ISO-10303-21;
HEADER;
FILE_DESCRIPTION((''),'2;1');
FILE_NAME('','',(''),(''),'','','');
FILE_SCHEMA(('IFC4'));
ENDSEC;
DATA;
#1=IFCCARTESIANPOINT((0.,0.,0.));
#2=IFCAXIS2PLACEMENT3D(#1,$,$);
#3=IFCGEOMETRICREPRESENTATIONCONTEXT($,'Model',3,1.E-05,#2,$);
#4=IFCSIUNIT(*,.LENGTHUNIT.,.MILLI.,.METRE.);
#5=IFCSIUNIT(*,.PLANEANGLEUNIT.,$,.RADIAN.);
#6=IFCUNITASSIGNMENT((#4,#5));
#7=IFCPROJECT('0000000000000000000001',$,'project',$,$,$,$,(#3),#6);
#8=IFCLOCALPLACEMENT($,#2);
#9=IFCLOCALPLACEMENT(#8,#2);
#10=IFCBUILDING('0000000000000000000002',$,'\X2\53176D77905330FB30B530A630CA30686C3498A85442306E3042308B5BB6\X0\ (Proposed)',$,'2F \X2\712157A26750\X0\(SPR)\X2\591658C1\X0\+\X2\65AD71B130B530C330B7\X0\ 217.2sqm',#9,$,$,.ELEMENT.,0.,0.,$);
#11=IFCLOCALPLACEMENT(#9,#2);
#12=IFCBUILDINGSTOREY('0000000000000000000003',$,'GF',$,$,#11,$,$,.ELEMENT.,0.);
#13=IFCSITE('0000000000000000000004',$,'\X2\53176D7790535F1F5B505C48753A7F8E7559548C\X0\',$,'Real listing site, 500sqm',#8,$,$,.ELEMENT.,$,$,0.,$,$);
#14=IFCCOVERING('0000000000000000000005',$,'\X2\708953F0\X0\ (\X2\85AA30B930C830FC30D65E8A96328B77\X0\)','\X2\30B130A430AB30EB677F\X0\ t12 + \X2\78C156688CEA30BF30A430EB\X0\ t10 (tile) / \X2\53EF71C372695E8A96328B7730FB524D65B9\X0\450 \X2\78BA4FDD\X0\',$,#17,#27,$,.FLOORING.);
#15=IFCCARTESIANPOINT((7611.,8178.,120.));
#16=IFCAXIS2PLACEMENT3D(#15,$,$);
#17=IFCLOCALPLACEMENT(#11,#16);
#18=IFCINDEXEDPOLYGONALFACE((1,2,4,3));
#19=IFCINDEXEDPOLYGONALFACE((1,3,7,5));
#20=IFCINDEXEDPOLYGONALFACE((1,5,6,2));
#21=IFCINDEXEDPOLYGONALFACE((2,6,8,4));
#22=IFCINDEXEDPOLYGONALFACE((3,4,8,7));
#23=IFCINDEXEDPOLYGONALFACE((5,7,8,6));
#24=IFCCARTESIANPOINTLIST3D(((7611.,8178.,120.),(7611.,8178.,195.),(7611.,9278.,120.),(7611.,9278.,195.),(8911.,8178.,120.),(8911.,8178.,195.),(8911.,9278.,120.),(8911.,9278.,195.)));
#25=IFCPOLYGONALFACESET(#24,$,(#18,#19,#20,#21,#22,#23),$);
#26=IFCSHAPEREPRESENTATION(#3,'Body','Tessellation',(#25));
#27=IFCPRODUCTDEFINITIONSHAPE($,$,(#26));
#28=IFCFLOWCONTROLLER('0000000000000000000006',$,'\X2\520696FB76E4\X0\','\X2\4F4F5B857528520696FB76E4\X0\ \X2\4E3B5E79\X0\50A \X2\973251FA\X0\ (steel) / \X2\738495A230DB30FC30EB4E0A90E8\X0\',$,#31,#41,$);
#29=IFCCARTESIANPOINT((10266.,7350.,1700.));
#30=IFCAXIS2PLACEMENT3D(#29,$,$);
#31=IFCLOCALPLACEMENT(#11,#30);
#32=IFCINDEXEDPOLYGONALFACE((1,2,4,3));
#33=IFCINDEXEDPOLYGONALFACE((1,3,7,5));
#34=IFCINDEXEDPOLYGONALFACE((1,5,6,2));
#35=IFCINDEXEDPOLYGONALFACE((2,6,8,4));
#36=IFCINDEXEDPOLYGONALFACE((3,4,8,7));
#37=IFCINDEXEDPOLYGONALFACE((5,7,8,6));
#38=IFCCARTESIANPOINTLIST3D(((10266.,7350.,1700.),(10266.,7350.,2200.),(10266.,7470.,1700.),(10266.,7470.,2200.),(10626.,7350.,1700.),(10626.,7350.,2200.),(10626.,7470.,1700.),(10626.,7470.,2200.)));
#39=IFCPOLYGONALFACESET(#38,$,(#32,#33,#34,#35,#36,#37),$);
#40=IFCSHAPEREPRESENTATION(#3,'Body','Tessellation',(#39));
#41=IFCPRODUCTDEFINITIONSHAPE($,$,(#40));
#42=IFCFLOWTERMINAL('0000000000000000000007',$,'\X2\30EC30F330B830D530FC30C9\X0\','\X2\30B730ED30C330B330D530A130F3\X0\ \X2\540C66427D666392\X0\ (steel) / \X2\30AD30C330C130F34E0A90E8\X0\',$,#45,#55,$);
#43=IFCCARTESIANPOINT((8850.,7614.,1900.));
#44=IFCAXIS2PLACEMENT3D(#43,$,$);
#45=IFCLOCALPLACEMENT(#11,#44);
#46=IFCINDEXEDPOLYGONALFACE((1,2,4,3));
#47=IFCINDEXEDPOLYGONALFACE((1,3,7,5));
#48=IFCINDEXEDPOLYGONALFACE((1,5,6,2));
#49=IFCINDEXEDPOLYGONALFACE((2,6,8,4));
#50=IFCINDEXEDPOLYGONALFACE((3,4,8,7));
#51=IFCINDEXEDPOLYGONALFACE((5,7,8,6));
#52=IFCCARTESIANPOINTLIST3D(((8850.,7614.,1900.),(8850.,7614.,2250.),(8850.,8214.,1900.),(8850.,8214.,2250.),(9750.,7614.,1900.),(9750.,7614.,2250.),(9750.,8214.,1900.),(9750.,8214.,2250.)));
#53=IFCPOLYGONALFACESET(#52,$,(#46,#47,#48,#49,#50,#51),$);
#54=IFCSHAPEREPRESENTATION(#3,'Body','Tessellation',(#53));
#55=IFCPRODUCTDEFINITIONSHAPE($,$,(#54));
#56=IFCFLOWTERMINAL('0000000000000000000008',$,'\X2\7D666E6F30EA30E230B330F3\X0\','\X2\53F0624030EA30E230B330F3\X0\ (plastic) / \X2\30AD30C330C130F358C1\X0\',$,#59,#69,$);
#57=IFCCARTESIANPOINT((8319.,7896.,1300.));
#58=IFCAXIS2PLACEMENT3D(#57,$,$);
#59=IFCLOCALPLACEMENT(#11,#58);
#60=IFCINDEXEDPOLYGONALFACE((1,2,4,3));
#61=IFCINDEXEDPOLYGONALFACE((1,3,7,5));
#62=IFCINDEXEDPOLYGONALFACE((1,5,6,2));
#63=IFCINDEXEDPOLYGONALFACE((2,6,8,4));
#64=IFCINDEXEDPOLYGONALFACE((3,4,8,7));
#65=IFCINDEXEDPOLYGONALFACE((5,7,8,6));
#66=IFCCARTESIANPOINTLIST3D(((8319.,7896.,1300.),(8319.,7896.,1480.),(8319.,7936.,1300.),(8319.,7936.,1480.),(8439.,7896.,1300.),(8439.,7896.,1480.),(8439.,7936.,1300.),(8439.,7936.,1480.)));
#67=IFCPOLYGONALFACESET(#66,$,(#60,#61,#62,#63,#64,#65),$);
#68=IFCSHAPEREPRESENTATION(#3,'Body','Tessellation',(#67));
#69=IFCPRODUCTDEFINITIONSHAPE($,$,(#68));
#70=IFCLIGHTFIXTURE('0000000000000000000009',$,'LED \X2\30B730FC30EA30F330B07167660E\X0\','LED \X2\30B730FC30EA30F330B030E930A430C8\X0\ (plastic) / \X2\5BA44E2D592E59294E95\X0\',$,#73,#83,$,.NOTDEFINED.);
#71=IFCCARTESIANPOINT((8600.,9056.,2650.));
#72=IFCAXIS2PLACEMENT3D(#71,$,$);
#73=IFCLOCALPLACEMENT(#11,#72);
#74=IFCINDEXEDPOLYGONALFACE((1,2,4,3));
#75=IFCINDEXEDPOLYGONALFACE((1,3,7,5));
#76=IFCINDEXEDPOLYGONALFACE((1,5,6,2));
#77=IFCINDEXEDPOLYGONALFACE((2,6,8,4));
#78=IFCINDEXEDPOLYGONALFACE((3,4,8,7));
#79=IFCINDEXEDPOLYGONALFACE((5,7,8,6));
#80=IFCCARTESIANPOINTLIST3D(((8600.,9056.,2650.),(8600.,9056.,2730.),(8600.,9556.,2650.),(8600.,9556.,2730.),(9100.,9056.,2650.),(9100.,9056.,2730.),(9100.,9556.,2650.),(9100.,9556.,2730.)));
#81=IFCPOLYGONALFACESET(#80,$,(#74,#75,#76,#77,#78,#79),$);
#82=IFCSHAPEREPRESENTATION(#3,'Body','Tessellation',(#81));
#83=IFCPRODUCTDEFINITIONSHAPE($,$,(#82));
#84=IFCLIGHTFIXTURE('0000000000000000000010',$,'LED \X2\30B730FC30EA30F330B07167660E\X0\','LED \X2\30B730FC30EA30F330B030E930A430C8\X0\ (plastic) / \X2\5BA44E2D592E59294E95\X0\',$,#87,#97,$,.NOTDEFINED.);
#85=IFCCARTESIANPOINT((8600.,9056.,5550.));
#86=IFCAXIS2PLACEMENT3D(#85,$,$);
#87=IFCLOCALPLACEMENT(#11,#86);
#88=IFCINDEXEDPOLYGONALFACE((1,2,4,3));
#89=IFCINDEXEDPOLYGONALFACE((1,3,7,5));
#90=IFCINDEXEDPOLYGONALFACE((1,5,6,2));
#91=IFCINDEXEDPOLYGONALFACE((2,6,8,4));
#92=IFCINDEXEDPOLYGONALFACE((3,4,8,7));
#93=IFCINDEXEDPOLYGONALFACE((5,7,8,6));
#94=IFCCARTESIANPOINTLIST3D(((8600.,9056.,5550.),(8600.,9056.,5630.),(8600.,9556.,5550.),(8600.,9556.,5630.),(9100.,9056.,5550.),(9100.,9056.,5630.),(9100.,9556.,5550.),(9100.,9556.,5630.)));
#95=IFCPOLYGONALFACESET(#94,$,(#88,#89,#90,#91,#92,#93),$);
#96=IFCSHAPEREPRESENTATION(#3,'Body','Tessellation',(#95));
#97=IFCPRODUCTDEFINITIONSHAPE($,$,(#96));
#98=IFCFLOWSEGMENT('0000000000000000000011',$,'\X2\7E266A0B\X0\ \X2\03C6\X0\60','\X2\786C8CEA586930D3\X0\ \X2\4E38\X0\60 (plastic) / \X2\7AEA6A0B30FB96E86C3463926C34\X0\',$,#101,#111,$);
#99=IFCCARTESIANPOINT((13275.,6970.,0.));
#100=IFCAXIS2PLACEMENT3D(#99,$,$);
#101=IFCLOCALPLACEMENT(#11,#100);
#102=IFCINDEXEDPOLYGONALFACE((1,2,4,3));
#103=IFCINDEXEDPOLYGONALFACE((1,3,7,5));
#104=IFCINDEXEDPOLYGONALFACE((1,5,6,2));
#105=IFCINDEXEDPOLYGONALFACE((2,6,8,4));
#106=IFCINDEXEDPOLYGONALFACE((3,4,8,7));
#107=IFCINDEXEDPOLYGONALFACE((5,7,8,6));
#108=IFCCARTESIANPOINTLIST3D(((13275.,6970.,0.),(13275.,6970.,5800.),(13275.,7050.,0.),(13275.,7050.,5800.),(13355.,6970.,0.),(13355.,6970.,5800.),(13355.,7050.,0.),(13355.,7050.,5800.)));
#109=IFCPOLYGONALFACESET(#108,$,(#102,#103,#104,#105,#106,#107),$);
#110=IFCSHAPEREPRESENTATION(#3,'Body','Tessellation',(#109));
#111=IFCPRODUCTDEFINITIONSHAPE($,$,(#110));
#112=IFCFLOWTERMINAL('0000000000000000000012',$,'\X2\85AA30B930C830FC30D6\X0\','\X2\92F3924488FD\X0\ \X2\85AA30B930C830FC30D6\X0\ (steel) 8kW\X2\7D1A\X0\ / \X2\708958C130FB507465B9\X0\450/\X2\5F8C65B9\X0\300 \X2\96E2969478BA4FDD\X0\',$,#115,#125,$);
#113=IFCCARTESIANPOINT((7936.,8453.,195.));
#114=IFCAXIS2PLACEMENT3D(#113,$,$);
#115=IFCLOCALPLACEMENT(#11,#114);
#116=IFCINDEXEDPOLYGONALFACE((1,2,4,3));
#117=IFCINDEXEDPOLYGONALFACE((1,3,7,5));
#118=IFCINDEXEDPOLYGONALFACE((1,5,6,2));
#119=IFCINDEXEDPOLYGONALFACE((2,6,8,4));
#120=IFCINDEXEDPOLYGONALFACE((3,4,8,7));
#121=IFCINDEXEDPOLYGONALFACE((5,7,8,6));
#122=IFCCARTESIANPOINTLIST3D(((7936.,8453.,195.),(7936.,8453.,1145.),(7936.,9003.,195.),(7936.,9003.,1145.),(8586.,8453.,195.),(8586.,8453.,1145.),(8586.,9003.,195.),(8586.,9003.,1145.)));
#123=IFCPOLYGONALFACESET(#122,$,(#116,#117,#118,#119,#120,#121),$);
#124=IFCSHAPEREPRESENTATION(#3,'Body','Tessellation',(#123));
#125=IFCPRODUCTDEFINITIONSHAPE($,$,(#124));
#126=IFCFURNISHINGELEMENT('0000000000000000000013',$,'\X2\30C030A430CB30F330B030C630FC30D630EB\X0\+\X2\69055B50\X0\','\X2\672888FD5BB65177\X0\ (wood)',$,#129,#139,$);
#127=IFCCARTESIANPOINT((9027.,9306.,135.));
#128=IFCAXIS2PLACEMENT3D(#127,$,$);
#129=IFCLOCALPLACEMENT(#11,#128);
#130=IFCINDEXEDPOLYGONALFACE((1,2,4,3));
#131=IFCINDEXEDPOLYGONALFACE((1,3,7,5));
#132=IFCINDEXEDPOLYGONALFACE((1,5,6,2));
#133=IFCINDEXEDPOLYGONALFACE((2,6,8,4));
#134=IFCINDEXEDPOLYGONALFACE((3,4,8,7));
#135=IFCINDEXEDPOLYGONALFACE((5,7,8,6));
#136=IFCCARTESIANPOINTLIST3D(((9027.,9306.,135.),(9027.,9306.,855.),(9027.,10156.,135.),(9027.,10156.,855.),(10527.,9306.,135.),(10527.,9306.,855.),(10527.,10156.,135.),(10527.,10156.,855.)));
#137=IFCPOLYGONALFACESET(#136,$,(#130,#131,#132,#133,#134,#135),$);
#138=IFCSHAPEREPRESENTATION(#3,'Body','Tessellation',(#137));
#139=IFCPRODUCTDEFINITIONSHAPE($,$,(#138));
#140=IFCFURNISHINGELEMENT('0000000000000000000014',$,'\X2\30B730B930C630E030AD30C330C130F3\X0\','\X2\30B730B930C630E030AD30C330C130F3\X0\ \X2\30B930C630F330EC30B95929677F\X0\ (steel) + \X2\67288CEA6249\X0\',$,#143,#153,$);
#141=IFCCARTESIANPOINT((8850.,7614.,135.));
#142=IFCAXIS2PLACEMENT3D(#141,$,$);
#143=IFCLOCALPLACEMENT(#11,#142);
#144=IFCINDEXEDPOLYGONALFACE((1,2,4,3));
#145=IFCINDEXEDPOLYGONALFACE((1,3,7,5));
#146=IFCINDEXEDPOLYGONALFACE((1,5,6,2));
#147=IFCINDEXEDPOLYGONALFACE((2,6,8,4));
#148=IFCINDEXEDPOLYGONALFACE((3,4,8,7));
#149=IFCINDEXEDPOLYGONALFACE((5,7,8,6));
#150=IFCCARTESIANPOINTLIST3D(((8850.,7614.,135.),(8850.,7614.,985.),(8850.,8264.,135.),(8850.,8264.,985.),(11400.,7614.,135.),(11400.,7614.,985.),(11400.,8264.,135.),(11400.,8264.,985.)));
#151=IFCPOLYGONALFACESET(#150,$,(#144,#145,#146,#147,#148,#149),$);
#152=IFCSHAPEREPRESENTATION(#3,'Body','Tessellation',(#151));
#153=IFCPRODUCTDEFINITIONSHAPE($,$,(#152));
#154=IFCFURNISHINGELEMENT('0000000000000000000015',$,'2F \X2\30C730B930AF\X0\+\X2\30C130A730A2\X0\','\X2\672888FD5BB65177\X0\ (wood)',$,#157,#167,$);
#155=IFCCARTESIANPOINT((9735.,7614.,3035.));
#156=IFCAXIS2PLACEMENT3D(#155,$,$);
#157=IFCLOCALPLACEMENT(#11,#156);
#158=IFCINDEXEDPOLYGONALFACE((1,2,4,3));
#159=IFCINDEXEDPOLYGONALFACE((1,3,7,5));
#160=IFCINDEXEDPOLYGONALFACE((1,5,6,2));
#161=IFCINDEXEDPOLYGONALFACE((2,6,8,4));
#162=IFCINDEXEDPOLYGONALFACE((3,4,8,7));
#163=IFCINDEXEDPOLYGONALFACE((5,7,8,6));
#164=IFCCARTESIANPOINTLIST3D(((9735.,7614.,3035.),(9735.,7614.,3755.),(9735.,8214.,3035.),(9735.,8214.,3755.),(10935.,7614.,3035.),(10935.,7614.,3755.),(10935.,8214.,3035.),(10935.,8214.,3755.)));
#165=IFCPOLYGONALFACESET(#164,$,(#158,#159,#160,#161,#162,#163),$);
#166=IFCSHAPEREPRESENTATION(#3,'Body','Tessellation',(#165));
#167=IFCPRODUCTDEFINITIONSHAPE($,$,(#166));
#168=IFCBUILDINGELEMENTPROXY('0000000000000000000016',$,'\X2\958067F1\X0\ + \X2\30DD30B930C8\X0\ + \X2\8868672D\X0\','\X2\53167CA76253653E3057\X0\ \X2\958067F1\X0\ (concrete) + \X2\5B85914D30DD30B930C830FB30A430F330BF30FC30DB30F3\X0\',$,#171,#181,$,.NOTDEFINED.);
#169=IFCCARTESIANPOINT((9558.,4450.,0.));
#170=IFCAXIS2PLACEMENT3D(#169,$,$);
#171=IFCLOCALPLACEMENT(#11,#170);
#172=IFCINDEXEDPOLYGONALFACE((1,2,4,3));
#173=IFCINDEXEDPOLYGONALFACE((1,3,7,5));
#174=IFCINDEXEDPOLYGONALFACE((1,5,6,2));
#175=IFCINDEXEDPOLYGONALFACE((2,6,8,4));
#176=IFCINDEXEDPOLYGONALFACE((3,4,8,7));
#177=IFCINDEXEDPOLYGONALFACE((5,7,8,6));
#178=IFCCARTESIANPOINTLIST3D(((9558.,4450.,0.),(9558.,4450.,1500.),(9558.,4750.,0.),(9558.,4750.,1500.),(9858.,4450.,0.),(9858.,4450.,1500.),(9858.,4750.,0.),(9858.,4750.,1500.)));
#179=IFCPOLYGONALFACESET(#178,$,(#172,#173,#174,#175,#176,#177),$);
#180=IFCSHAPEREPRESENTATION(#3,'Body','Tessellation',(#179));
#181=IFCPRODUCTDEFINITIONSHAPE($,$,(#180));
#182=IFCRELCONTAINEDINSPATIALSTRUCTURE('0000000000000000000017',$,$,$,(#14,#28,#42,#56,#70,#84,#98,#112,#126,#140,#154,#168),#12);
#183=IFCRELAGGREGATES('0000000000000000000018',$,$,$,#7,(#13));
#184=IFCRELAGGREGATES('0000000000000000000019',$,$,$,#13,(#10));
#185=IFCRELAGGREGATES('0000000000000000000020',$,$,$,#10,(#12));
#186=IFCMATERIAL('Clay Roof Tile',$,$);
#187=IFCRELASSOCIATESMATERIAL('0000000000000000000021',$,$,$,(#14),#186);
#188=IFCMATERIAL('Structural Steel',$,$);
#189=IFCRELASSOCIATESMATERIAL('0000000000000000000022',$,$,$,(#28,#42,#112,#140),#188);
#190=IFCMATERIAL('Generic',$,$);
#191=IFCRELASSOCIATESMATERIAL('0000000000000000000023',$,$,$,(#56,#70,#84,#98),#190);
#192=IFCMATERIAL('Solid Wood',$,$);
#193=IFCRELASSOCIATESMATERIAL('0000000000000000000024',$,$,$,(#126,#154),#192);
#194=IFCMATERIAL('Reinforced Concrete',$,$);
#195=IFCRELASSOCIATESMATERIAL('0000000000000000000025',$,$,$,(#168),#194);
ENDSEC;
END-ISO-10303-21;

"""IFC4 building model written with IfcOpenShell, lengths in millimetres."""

from ifc_helpers import new_model, si_unit, frame, frame_2d, origin, place, context, project, spatial, rectangle, extrude, material, element, save


model = new_model("IFC4")

# Units and contexts
model_context = context("Model", 3, precision=1e-05, world=origin())
ifc_project = project(units=[si_unit("LENGTHUNIT", "METRE", prefix="MILLI"), si_unit("PLANEANGLEUNIT", "RADIAN")], contexts=[model_context])

# Site, building, storey
site_placement = place(None, origin())
site = spatial("IfcSite", under=ifc_project, at=site_placement, Name="北海道弟子屈町美留和", ObjectType="Real listing site, 500sqm", CompositionType="ELEMENT", RefElevation=0.0)
building_placement = place(site_placement, origin())
building = spatial("IfcBuilding", under=site, at=building_placement, Name="北海道・サウナと水風呂のある家 (Proposed)", ObjectType="2F 無垢材(SPR)外壁+断熱サッシ 217.2sqm", CompositionType="ELEMENT", ElevationOfRefHeight=0.0, ElevationOfTerrain=0.0)
storey_placement = place(building_placement, origin())
storey = spatial("IfcBuildingStorey", under=building, at=storey_placement, Name="GF", CompositionType="ELEMENT", Elevation=0.0)

# Shared definitions
ifc_material_1 = material(Name="Solid Wood")

# Shared definitions
ifc_material_2 = material(Name="Structural Steel")

# Covering
ifc_material_3 = material(Name="Reinforced Concrete")
ifc_material_4 = material(Name="Clay Roof Tile")
covering_1_placement = place(storey_placement, frame((7611.0, 8178.0, 120.0)))
element("IfcCovering", 1, at=covering_1_placement, inside=storey, material=ifc_material_4, Name="炉台 (薪ストーブ床防護)", Description="ケイカル板 t12 + 磁器質タイル t10 (tile) / 可燃物床防護・前方450 確保", PredefinedType="FLOORING", context=model_context, shape_type="SweptSolid", body=[
    extrude(rectangle(XDim=1300.0, YDim=1100.0, at=frame_2d((650.0, 550.0))), frame((7611.0, 8178.0, 120.0)), (0.0, 0.0, 1.0), 75.0),
])

# Flow controller
flow_controller_placement = place(storey_placement, frame((10266.0, 7350.0, 1700.0)))
element("IfcFlowController", 2, at=flow_controller_placement, inside=storey, material=ifc_material_2, Name="分電盤", Description="住宅用分電盤 主幹50A 露出 (steel) / 玄関ホール上部", context=model_context, shape_type="SweptSolid", body=[
    extrude(rectangle(XDim=360.0, YDim=120.0, at=frame_2d((180.0, 60.0))), frame((10266.0, 7350.0, 1700.0)), (0.0, 0.0, 1.0), 500.0),
])

# Flow terminals
flow_terminal_1_placement = place(storey_placement, frame((8850.0, 7614.0, 1900.0)))
element("IfcFlowTerminal", 3, at=flow_terminal_1_placement, inside=storey, material=ifc_material_2, Name="レンジフード", Description="シロッコファン 同時給排 (steel) / キッチン上部", context=model_context, shape_type="SweptSolid", body=[
    extrude(rectangle(XDim=900.0, YDim=600.0, at=frame_2d((450.0, 300.0))), frame((8850.0, 7614.0, 1900.0)), (0.0, 0.0, 1.0), 350.0),
])
ifc_material_5 = material(Name="Generic")
flow_terminal_2_placement = place(storey_placement, frame((8319.0, 7896.0, 1300.0)))
element("IfcFlowTerminal", 4, at=flow_terminal_2_placement, inside=storey, material=ifc_material_5, Name="給湯リモコン", Description="台所リモコン (plastic) / キッチン壁", context=model_context, shape_type="SweptSolid", body=[
    extrude(rectangle(XDim=120.0, YDim=40.0, at=frame_2d((60.0, 20.0))), frame((8319.0, 7896.0, 1300.0)), (0.0, 0.0, 1.0), 180.0),
])

# Light fixtures
light_fixture_1_placement = place(storey_placement, frame((8600.0, 9056.0, 2650.0)))
element("IfcLightFixture", 5, at=light_fixture_1_placement, inside=storey, material=ifc_material_5, Name="LED シーリング照明", Description="LED シーリングライト (plastic) / 室中央天井", PredefinedType="NOTDEFINED", context=model_context, shape_type="SweptSolid", body=[
    extrude(rectangle(XDim=500.0, YDim=500.0, at=frame_2d((250.0, 250.0))), frame((8600.0, 9056.0, 2650.0)), (0.0, 0.0, 1.0), 80.0),
])
light_fixture_2_placement = place(storey_placement, frame((8600.0, 9056.0, 5550.0)))
element("IfcLightFixture", 6, at=light_fixture_2_placement, inside=storey, material=ifc_material_5, Name="LED シーリング照明", Description="LED シーリングライト (plastic) / 室中央天井", PredefinedType="NOTDEFINED", context=model_context, shape_type="SweptSolid", body=[
    extrude(rectangle(XDim=500.0, YDim=500.0, at=frame_2d((250.0, 250.0))), frame((8600.0, 9056.0, 5550.0)), (0.0, 0.0, 1.0), 80.0),
])

# Flow segment
flow_segment_placement = place(storey_placement, frame((13275.0, 6970.0, 0.0)))
element("IfcFlowSegment", 7, at=flow_segment_placement, inside=storey, material=ifc_material_5, Name="縦樋 φ60", Description="硬質塩ビ 丸60 (plastic) / 竪樋・雨水排水", context=model_context, shape_type="SweptSolid", body=[
    extrude(rectangle(XDim=80.0, YDim=80.0, at=frame_2d((40.0, 40.0))), frame((13275.0, 6970.0, 0.0)), (0.0, 0.0, 1.0), 5800.0),
])

# Flow terminal
flow_terminal_3_placement = place(storey_placement, frame((7936.0, 8453.0, 195.0)))
element("IfcFlowTerminal", 8, at=flow_terminal_3_placement, inside=storey, material=ifc_material_2, Name="薪ストーブ", Description="鋳鉄製 薪ストーブ (steel) 8kW級 / 炉壁・側方450/後方300 離隔確保", context=model_context, shape_type="SweptSolid", body=[
    extrude(rectangle(XDim=650.0, YDim=550.0, at=frame_2d((325.0, 275.0))), frame((7936.0, 8453.0, 195.0)), (0.0, 0.0, 1.0), 950.0),
])

# Furnishing elements
furnishing_1_placement = place(storey_placement, frame((9027.0, 9306.0, 135.0)))
element("IfcFurnishingElement", 9, at=furnishing_1_placement, inside=storey, material=ifc_material_1, Name="ダイニングテーブル+椅子", Description="木製家具 (wood)", context=model_context, shape_type="SweptSolid", body=[
    extrude(rectangle(XDim=1500.0, YDim=850.0, at=frame_2d((750.0, 425.0))), frame((9027.0, 9306.0, 135.0)), (0.0, 0.0, 1.0), 720.0),
])
furnishing_2_placement = place(storey_placement, frame((8850.0, 7614.0, 135.0)))
element("IfcFurnishingElement", 10, at=furnishing_2_placement, inside=storey, material=ifc_material_2, Name="システムキッチン", Description="システムキッチン ステンレス天板 (steel) + 木質扉", context=model_context, shape_type="SweptSolid", body=[
    extrude(rectangle(XDim=2550.0, YDim=650.0, at=frame_2d((1275.0, 325.0))), frame((8850.0, 7614.0, 135.0)), (0.0, 0.0, 1.0), 850.0),
])
furnishing_3_placement = place(storey_placement, frame((9735.0, 7614.0, 3035.0)))
element("IfcFurnishingElement", 11, at=furnishing_3_placement, inside=storey, material=ifc_material_1, Name="2F デスク+チェア", Description="木製家具 (wood)", context=model_context, shape_type="SweptSolid", body=[
    extrude(rectangle(XDim=1200.0, YDim=600.0, at=frame_2d((600.0, 300.0))), frame((9735.0, 7614.0, 3035.0)), (0.0, 0.0, 1.0), 720.0),
])

# Building element proxy
proxy_placement = place(storey_placement, frame((9558.0, 4450.0, 0.0)))
element("IfcBuildingElementProxy", 12, at=proxy_placement, inside=storey, material=ifc_material_3, Name="門柱 + ポスト + 表札", Description="化粧打放し 門柱 (concrete) + 宅配ポスト・インターホン", PredefinedType="NOTDEFINED", context=model_context, shape_type="SweptSolid", body=[
    extrude(rectangle(XDim=300.0, YDim=300.0, at=frame_2d((150.0, 150.0))), frame((9558.0, 4450.0, 0.0)), (0.0, 0.0, 1.0), 1500.0),
])

save(model, "model.ifc")
